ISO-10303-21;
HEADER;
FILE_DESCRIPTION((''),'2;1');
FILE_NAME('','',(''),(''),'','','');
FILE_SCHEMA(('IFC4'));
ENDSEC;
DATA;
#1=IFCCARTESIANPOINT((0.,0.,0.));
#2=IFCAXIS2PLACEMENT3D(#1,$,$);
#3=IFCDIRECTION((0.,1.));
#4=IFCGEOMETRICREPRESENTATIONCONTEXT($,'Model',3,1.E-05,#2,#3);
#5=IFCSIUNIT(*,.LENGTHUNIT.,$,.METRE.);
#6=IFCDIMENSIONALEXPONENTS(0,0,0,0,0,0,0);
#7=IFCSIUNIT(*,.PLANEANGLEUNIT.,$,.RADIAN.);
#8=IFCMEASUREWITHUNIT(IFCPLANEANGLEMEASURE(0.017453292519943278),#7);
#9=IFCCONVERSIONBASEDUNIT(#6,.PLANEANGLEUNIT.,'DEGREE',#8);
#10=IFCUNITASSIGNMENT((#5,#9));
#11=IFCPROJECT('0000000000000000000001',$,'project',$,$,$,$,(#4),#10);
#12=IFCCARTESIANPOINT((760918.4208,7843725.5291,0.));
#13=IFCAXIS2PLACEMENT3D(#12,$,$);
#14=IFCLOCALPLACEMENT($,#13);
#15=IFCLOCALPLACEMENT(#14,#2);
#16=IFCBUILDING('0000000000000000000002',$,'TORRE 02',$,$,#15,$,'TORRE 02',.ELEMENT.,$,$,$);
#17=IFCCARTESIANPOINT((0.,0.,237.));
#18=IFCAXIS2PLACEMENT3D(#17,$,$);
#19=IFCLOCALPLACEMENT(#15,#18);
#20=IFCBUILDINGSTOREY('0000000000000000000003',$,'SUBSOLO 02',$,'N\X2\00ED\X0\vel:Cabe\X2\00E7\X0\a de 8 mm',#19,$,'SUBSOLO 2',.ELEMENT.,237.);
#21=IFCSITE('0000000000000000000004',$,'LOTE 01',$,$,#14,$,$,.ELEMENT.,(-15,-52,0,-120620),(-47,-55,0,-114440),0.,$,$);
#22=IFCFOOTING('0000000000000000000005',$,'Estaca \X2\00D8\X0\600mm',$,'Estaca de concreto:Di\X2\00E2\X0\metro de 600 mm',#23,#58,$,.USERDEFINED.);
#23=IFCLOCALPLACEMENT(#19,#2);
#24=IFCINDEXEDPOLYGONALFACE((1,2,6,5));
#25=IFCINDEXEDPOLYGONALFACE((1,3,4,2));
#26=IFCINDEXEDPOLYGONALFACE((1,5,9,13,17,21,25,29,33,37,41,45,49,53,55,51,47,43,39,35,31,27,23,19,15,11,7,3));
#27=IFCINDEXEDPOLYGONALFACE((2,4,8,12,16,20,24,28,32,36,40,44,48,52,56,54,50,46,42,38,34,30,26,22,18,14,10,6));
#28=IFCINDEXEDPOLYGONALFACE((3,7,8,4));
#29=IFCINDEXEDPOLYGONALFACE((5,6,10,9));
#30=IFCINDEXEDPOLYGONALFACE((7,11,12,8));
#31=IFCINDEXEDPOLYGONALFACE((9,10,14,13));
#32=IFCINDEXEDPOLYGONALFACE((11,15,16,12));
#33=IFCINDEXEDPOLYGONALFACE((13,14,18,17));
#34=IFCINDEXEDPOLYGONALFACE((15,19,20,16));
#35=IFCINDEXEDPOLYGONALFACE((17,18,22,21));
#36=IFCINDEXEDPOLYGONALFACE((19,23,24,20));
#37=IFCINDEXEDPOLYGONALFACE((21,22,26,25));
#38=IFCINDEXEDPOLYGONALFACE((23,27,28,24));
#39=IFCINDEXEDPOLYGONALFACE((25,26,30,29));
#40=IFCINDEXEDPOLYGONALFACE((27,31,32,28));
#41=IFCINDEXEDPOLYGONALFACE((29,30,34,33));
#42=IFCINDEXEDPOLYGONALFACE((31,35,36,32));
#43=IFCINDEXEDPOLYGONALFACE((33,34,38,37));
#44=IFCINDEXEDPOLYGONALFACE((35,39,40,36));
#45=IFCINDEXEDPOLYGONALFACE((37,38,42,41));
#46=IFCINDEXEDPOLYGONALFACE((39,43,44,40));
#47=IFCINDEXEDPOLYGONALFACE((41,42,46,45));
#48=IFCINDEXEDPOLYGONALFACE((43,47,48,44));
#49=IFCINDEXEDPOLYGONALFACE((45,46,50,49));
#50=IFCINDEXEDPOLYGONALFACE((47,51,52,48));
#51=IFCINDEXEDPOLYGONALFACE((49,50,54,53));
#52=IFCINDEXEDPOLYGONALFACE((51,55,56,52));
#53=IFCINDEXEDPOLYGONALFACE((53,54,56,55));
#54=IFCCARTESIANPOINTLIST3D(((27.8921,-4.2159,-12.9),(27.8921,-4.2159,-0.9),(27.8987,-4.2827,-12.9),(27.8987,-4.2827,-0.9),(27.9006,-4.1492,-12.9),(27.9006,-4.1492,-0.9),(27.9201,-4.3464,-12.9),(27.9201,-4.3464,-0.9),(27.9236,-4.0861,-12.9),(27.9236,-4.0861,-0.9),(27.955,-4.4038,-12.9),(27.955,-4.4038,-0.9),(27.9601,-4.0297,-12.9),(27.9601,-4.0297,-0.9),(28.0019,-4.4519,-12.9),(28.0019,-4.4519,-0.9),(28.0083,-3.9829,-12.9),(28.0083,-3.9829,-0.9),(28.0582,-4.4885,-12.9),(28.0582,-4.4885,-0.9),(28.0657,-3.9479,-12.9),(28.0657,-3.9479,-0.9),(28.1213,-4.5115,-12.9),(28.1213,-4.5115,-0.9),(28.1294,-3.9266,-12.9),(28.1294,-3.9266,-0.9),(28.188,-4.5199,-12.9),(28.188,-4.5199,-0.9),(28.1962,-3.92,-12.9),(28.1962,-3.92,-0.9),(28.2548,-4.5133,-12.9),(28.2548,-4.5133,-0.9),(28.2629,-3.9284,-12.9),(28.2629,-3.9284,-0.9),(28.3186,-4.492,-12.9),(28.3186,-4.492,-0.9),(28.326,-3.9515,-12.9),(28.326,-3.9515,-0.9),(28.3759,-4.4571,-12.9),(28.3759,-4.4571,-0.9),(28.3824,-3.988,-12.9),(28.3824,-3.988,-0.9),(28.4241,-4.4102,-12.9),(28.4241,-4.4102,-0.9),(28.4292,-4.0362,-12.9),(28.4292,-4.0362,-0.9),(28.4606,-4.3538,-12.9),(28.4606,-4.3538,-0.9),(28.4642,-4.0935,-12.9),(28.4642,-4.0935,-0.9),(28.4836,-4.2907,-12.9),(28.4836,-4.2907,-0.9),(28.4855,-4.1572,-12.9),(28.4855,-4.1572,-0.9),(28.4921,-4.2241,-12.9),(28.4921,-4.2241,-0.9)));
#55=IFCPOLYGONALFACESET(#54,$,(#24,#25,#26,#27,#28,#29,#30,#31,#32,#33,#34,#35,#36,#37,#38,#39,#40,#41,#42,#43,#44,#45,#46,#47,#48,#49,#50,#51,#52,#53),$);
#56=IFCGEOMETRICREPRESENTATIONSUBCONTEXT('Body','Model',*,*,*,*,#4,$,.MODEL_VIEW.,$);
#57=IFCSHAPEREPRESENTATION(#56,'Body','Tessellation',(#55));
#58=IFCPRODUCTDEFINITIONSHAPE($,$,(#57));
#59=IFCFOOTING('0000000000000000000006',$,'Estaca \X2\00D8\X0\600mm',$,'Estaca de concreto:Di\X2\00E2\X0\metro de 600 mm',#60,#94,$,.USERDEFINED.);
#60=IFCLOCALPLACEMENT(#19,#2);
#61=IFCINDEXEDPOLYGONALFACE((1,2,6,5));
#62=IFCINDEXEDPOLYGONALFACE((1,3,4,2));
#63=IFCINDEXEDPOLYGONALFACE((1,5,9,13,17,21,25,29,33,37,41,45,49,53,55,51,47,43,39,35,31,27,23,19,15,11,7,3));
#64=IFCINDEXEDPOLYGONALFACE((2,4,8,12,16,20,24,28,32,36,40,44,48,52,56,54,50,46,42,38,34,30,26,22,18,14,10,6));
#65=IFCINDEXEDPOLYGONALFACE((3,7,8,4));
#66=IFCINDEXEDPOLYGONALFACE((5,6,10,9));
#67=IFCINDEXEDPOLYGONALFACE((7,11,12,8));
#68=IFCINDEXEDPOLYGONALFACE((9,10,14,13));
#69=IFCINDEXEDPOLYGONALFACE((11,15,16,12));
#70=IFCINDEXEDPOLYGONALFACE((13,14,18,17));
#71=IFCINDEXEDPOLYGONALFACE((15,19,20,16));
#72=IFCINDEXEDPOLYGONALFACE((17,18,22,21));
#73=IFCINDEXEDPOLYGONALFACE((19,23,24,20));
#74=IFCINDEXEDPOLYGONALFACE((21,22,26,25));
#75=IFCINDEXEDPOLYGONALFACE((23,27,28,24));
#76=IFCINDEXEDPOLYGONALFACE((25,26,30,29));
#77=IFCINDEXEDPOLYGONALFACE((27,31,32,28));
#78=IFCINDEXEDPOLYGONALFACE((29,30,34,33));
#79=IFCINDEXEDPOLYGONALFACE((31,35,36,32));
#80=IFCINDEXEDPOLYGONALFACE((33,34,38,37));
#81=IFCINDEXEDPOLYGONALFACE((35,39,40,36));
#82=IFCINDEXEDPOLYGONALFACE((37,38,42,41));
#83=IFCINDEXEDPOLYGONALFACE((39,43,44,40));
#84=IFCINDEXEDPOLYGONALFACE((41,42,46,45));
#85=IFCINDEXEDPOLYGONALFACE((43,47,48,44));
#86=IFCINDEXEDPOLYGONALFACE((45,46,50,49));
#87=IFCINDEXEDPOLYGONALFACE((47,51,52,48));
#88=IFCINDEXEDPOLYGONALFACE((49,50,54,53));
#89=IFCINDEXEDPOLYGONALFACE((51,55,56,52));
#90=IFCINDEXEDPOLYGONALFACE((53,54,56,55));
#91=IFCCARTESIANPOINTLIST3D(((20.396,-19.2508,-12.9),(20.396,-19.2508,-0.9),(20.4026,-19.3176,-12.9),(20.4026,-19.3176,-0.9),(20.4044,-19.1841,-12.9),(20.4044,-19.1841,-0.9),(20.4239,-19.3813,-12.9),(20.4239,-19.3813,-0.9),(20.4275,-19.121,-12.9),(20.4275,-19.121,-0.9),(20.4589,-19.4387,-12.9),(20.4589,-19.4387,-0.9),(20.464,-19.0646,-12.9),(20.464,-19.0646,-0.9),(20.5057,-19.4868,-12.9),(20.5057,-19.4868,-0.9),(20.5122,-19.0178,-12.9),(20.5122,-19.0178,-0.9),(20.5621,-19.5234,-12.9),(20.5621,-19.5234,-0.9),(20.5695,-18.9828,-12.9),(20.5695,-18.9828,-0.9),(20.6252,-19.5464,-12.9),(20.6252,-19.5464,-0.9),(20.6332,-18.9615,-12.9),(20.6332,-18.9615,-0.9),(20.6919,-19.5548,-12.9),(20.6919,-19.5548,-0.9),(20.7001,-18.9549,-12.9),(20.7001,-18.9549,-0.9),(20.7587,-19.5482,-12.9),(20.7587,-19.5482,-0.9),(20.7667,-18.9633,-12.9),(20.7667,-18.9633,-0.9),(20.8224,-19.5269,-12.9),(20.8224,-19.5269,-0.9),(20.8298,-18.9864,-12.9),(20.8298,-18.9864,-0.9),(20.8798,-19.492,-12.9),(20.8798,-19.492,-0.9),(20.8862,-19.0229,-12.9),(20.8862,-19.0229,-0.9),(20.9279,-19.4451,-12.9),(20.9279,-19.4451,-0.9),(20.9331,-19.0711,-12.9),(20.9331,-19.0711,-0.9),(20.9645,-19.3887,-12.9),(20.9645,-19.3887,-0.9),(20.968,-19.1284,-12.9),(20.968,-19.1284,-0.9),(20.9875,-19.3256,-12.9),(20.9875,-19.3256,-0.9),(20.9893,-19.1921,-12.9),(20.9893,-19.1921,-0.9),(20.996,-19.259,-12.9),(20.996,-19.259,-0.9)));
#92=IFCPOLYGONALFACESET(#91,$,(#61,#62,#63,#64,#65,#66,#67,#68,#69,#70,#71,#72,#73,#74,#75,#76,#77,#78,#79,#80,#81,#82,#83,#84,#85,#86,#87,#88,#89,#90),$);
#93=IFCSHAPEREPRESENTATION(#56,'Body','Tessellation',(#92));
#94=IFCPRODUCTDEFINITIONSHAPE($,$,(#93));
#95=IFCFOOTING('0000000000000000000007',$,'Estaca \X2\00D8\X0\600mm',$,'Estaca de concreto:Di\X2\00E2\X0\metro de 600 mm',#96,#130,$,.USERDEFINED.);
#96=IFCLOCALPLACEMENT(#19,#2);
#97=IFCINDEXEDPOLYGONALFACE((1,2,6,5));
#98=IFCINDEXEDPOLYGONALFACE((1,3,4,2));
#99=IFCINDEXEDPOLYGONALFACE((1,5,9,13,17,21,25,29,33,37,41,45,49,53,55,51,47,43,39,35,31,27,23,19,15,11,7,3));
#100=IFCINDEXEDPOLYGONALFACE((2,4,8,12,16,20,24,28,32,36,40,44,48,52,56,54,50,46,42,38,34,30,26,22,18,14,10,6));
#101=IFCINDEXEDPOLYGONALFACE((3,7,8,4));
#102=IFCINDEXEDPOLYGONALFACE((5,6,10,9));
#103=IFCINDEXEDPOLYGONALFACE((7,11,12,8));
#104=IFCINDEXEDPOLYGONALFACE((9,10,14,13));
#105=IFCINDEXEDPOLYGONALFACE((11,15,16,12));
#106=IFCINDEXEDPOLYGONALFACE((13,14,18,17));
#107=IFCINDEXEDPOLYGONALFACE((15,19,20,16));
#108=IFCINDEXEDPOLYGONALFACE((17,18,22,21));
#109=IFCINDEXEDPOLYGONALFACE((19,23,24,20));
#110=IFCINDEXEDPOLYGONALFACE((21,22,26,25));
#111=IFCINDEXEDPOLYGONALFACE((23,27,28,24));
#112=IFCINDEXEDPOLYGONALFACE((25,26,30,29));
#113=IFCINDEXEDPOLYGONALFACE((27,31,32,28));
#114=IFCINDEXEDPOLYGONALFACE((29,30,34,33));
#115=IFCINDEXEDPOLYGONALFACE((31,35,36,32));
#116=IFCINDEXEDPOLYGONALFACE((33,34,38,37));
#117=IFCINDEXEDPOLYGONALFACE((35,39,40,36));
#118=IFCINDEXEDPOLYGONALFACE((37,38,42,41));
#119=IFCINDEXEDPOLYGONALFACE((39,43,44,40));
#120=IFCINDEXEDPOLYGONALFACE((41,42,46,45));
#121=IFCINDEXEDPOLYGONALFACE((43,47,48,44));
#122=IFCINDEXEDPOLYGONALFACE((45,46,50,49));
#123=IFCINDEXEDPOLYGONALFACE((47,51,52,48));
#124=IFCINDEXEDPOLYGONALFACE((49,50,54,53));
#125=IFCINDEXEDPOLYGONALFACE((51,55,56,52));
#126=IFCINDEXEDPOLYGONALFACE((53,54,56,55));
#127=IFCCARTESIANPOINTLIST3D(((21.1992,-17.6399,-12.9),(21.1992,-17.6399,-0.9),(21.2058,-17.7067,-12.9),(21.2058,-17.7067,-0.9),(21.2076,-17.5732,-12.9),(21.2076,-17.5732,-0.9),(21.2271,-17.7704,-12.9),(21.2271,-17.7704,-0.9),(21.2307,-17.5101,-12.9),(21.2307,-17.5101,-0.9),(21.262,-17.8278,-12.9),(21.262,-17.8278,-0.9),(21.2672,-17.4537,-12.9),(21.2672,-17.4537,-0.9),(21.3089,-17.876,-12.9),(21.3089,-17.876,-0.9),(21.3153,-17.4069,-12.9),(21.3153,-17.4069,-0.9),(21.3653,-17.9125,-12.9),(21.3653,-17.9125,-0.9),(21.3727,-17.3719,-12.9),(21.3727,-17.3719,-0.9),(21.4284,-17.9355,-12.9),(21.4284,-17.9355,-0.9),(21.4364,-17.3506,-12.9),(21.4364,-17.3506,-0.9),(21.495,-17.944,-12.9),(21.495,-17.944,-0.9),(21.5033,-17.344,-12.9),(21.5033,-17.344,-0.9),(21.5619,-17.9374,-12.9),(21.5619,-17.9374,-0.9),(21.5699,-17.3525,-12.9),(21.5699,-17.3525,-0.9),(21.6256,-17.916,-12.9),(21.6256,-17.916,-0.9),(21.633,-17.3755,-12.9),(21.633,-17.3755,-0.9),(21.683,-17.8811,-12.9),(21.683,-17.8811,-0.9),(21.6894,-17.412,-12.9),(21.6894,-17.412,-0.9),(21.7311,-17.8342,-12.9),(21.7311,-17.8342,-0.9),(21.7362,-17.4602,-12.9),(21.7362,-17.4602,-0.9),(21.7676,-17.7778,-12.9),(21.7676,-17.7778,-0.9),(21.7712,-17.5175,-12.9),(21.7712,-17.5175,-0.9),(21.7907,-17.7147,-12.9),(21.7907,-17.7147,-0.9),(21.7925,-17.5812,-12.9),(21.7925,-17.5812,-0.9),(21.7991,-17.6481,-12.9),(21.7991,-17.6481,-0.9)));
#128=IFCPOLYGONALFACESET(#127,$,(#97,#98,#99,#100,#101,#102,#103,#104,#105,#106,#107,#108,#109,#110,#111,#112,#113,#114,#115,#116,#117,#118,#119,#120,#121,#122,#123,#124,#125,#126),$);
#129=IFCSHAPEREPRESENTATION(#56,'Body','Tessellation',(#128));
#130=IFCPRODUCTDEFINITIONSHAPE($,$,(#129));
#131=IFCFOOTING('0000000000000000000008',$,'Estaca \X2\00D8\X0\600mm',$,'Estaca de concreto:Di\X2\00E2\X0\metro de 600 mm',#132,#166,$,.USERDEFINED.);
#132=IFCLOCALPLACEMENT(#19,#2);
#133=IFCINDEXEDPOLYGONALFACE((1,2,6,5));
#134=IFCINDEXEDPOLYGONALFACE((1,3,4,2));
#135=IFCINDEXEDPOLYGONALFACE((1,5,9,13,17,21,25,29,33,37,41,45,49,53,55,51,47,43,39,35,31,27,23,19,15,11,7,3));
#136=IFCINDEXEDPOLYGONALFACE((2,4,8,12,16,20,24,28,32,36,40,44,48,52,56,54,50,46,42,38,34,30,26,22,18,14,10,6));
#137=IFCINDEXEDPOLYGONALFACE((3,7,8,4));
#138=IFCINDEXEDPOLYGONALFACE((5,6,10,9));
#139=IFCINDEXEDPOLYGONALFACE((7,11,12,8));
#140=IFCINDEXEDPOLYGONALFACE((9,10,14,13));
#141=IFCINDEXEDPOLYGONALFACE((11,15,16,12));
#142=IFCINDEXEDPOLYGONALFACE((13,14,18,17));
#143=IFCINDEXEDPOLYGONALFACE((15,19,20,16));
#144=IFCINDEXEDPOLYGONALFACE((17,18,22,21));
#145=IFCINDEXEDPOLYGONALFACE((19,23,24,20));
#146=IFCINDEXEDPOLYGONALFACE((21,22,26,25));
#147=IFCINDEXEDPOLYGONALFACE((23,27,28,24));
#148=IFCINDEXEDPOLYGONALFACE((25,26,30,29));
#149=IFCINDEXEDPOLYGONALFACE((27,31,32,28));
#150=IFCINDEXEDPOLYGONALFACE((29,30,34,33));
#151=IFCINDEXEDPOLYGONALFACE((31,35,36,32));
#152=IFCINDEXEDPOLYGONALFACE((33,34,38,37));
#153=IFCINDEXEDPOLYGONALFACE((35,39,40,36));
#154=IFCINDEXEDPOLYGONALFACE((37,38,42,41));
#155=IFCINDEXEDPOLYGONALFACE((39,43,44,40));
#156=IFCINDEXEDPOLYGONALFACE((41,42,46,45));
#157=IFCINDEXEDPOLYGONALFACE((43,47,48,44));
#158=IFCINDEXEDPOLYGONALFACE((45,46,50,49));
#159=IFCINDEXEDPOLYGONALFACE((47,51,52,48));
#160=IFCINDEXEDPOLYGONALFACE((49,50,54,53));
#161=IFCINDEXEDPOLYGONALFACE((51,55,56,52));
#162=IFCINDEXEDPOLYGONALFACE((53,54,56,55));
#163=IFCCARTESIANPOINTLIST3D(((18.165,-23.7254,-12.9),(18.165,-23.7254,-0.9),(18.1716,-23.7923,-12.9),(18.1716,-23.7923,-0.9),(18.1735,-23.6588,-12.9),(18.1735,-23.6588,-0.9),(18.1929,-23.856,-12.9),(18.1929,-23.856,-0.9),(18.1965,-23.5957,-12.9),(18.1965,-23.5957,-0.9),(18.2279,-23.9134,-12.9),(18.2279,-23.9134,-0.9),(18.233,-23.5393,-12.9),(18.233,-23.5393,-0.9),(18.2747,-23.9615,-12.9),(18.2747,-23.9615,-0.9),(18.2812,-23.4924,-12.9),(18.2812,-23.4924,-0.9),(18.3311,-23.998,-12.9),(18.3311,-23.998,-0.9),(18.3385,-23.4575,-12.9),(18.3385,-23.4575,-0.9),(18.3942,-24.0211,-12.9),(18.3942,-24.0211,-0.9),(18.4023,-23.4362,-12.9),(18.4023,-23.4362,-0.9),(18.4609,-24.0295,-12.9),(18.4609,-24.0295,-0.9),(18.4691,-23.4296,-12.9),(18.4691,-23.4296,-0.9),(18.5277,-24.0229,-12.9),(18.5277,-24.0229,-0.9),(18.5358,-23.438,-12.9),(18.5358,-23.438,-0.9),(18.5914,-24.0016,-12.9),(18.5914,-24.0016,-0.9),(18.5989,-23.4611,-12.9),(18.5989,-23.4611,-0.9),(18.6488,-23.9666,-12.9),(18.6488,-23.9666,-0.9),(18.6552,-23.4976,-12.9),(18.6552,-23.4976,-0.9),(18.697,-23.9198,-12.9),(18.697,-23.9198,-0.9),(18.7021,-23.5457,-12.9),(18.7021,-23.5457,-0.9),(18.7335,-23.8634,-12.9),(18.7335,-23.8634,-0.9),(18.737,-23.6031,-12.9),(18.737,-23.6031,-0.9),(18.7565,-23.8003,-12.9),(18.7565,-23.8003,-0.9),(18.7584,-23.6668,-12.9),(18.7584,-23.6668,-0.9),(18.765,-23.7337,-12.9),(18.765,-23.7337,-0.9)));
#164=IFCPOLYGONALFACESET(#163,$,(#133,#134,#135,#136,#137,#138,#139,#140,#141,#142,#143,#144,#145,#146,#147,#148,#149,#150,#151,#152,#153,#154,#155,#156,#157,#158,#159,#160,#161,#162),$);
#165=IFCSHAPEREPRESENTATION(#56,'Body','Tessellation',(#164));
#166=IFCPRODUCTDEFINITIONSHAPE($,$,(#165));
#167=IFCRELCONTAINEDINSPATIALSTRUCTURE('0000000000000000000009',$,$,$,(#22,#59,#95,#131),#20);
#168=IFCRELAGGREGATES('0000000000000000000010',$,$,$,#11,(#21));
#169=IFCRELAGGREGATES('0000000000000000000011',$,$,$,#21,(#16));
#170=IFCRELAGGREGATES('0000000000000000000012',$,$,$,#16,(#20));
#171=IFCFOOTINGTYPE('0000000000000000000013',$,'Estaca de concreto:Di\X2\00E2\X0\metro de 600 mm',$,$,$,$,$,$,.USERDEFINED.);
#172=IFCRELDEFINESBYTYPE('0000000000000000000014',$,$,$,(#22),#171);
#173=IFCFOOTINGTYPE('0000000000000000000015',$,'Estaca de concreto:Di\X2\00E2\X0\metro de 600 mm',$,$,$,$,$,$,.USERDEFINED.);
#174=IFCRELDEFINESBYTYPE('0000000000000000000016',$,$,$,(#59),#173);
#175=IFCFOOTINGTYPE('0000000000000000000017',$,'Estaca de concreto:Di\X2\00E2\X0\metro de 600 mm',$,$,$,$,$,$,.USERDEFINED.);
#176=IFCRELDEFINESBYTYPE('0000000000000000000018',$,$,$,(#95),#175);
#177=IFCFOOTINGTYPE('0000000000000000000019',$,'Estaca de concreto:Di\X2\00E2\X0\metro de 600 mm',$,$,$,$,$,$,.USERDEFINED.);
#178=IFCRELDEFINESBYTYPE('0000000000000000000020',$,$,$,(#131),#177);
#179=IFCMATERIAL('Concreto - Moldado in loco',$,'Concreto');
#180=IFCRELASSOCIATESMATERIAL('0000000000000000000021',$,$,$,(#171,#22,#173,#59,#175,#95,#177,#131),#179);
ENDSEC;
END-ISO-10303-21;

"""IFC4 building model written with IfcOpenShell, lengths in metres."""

from ifc_helpers import new_model, entity, si_unit, converted_unit, direction, frame, origin, place, context, subcontext, project, spatial, arc, indexed_curve, outline, extrude, source, transform, mapped, material, type_object, type_shapes, element, save


model = new_model("IFC4")

# Units and contexts
model_context = context("Model", 3, precision=1e-05, world=origin(), true_north=direction((0.0, 1.0)))
body_context = subcontext(model_context, "Body", "Model", "MODEL_VIEW")
ifc_project = project(units=[si_unit("LENGTHUNIT", "METRE"), converted_unit("PLANEANGLEUNIT", "DEGREE", entity("IfcPlaneAngleMeasure", 0.017453292519943278), si_unit("PLANEANGLEUNIT", "RADIAN"), dimensions=[0, 0, 0, 0, 0, 0, 0])], contexts=[model_context])

# Site, building, storey
site_placement = place(None, frame((760918.4208, 7843725.5291, 0.0)))
site = spatial("IfcSite", under=ifc_project, at=site_placement, Name="LOTE 01", CompositionType="ELEMENT", RefLatitude=(-15, -52, 0, -120620), RefLongitude=(-47, -55, 0, -114440), RefElevation=0.0)
building_placement = place(site_placement, origin())
building = spatial("IfcBuilding", under=site, at=building_placement, Name="TORRE 02", LongName="TORRE 02", CompositionType="ELEMENT")
storey_placement = place(building_placement, frame((0.0, 0.0, 237.0)))
storey = spatial("IfcBuildingStorey", under=building, at=storey_placement, Name="SUBSOLO 02", ObjectType="Nível:Cabeça de 8 mm", LongName="SUBSOLO 2", CompositionType="ELEMENT", Elevation=237.0)

# Footings
ifc_material_1 = material(Name="Concreto - Moldado in loco", Category="Concreto")
placement = place(building_placement, frame((0.0, 0.0, 237.0)))
footing_type_1 = type_object("IfcFootingType", Name="Estaca de concreto:Diâmetro de 600 mm", PredefinedType="USERDEFINED", material=ifc_material_1)
shared_shape_1 = source(origin(), body_context, "Body", "SweptSolid", [
    extrude(outline(indexed_curve([(-0.3, 0.0), (0.0, -0.3), (0.3, 0.0), (0.0, 0.3)], segments=[arc(1, 2, 3), arc(3, 4, 1)], self_intersect=False)), frame((28.1921, -4.22, -12.0), z_axis=(0.0, 0.0, 1.0), x_axis=(0.446198, 0.894934, 0.0)), (0.0, 0.0, 1.0), 12.0),
])
type_shapes(footing_type_1, [shared_shape_1])
footing_1_placement = place(placement, frame((0.0, 0.0, -0.9)))
element("IfcFooting", 1, at=footing_1_placement, inside=storey, type_object=footing_type_1, material=ifc_material_1, Name="Estaca Ø600mm", ObjectType="Estaca de concreto:Diâmetro de 600 mm", PredefinedType="USERDEFINED", context=body_context, shape_type="MappedRepresentation", body=[
    mapped(shared_shape_1, transform((0.0, 0.0, 0.0), scale=1.0)),
])
footing_type_2 = type_object("IfcFootingType", Name="Estaca de concreto:Diâmetro de 600 mm", PredefinedType="USERDEFINED", material=ifc_material_1)
shared_shape_2 = source(origin(), body_context, "Body", "SweptSolid", [
    extrude(outline(indexed_curve([(-0.3, 0.0), (0.0, -0.3), (0.3, 0.0), (0.0, 0.3)], segments=[arc(1, 2, 3), arc(3, 4, 1)], self_intersect=False)), frame((20.696, -19.2549, -12.0), z_axis=(0.0, 0.0, 1.0), x_axis=(0.446198, 0.894934, 0.0)), (0.0, 0.0, 1.0), 12.0),
])
type_shapes(footing_type_2, [shared_shape_2])
footing_2_placement = place(placement, frame((0.0, 0.0, -0.9)))
element("IfcFooting", 2, at=footing_2_placement, inside=storey, type_object=footing_type_2, material=ifc_material_1, Name="Estaca Ø600mm", ObjectType="Estaca de concreto:Diâmetro de 600 mm", PredefinedType="USERDEFINED", context=body_context, shape_type="MappedRepresentation", body=[
    mapped(shared_shape_2, transform((0.0, 0.0, 0.0), scale=1.0)),
])
footing_type_3 = type_object("IfcFootingType", Name="Estaca de concreto:Diâmetro de 600 mm", PredefinedType="USERDEFINED", material=ifc_material_1)
shared_shape_3 = source(origin(), body_context, "Body", "SweptSolid", [
    extrude(outline(indexed_curve([(-0.3, 0.0), (0.0, -0.3), (0.3, 0.0), (0.0, 0.3)], segments=[arc(1, 2, 3), arc(3, 4, 1)], self_intersect=False)), frame((21.4991, -17.644, -12.0), z_axis=(0.0, 0.0, 1.0), x_axis=(0.446198, 0.894934, 0.0)), (0.0, 0.0, 1.0), 12.0),
])
type_shapes(footing_type_3, [shared_shape_3])
footing_3_placement = place(placement, frame((0.0, 0.0, -0.9)))
element("IfcFooting", 3, at=footing_3_placement, inside=storey, type_object=footing_type_3, material=ifc_material_1, Name="Estaca Ø600mm", ObjectType="Estaca de concreto:Diâmetro de 600 mm", PredefinedType="USERDEFINED", context=body_context, shape_type="MappedRepresentation", body=[
    mapped(shared_shape_3, transform((0.0, 0.0, 0.0), scale=1.0)),
])
footing_type_4 = type_object("IfcFootingType", Name="Estaca de concreto:Diâmetro de 600 mm", PredefinedType="USERDEFINED", material=ifc_material_1)
shared_shape_4 = source(origin(), body_context, "Body", "SweptSolid", [
    extrude(outline(indexed_curve([(-0.3, 0.0), (0.0, -0.3), (0.3, 0.0), (0.0, 0.3)], segments=[arc(1, 2, 3), arc(3, 4, 1)], self_intersect=False)), frame((18.465, -23.7295, -12.0), z_axis=(0.0, 0.0, 1.0), x_axis=(0.446198, 0.894934, 0.0)), (0.0, 0.0, 1.0), 12.0),
])
type_shapes(footing_type_4, [shared_shape_4])
footing_4_placement = place(placement, frame((0.0, 0.0, -0.9)))
element("IfcFooting", 4, at=footing_4_placement, inside=storey, type_object=footing_type_4, material=ifc_material_1, Name="Estaca Ø600mm", ObjectType="Estaca de concreto:Diâmetro de 600 mm", PredefinedType="USERDEFINED", context=body_context, shape_type="MappedRepresentation", body=[
    mapped(shared_shape_4, transform((0.0, 0.0, 0.0), scale=1.0)),
])

save(model, "model.ifc")
